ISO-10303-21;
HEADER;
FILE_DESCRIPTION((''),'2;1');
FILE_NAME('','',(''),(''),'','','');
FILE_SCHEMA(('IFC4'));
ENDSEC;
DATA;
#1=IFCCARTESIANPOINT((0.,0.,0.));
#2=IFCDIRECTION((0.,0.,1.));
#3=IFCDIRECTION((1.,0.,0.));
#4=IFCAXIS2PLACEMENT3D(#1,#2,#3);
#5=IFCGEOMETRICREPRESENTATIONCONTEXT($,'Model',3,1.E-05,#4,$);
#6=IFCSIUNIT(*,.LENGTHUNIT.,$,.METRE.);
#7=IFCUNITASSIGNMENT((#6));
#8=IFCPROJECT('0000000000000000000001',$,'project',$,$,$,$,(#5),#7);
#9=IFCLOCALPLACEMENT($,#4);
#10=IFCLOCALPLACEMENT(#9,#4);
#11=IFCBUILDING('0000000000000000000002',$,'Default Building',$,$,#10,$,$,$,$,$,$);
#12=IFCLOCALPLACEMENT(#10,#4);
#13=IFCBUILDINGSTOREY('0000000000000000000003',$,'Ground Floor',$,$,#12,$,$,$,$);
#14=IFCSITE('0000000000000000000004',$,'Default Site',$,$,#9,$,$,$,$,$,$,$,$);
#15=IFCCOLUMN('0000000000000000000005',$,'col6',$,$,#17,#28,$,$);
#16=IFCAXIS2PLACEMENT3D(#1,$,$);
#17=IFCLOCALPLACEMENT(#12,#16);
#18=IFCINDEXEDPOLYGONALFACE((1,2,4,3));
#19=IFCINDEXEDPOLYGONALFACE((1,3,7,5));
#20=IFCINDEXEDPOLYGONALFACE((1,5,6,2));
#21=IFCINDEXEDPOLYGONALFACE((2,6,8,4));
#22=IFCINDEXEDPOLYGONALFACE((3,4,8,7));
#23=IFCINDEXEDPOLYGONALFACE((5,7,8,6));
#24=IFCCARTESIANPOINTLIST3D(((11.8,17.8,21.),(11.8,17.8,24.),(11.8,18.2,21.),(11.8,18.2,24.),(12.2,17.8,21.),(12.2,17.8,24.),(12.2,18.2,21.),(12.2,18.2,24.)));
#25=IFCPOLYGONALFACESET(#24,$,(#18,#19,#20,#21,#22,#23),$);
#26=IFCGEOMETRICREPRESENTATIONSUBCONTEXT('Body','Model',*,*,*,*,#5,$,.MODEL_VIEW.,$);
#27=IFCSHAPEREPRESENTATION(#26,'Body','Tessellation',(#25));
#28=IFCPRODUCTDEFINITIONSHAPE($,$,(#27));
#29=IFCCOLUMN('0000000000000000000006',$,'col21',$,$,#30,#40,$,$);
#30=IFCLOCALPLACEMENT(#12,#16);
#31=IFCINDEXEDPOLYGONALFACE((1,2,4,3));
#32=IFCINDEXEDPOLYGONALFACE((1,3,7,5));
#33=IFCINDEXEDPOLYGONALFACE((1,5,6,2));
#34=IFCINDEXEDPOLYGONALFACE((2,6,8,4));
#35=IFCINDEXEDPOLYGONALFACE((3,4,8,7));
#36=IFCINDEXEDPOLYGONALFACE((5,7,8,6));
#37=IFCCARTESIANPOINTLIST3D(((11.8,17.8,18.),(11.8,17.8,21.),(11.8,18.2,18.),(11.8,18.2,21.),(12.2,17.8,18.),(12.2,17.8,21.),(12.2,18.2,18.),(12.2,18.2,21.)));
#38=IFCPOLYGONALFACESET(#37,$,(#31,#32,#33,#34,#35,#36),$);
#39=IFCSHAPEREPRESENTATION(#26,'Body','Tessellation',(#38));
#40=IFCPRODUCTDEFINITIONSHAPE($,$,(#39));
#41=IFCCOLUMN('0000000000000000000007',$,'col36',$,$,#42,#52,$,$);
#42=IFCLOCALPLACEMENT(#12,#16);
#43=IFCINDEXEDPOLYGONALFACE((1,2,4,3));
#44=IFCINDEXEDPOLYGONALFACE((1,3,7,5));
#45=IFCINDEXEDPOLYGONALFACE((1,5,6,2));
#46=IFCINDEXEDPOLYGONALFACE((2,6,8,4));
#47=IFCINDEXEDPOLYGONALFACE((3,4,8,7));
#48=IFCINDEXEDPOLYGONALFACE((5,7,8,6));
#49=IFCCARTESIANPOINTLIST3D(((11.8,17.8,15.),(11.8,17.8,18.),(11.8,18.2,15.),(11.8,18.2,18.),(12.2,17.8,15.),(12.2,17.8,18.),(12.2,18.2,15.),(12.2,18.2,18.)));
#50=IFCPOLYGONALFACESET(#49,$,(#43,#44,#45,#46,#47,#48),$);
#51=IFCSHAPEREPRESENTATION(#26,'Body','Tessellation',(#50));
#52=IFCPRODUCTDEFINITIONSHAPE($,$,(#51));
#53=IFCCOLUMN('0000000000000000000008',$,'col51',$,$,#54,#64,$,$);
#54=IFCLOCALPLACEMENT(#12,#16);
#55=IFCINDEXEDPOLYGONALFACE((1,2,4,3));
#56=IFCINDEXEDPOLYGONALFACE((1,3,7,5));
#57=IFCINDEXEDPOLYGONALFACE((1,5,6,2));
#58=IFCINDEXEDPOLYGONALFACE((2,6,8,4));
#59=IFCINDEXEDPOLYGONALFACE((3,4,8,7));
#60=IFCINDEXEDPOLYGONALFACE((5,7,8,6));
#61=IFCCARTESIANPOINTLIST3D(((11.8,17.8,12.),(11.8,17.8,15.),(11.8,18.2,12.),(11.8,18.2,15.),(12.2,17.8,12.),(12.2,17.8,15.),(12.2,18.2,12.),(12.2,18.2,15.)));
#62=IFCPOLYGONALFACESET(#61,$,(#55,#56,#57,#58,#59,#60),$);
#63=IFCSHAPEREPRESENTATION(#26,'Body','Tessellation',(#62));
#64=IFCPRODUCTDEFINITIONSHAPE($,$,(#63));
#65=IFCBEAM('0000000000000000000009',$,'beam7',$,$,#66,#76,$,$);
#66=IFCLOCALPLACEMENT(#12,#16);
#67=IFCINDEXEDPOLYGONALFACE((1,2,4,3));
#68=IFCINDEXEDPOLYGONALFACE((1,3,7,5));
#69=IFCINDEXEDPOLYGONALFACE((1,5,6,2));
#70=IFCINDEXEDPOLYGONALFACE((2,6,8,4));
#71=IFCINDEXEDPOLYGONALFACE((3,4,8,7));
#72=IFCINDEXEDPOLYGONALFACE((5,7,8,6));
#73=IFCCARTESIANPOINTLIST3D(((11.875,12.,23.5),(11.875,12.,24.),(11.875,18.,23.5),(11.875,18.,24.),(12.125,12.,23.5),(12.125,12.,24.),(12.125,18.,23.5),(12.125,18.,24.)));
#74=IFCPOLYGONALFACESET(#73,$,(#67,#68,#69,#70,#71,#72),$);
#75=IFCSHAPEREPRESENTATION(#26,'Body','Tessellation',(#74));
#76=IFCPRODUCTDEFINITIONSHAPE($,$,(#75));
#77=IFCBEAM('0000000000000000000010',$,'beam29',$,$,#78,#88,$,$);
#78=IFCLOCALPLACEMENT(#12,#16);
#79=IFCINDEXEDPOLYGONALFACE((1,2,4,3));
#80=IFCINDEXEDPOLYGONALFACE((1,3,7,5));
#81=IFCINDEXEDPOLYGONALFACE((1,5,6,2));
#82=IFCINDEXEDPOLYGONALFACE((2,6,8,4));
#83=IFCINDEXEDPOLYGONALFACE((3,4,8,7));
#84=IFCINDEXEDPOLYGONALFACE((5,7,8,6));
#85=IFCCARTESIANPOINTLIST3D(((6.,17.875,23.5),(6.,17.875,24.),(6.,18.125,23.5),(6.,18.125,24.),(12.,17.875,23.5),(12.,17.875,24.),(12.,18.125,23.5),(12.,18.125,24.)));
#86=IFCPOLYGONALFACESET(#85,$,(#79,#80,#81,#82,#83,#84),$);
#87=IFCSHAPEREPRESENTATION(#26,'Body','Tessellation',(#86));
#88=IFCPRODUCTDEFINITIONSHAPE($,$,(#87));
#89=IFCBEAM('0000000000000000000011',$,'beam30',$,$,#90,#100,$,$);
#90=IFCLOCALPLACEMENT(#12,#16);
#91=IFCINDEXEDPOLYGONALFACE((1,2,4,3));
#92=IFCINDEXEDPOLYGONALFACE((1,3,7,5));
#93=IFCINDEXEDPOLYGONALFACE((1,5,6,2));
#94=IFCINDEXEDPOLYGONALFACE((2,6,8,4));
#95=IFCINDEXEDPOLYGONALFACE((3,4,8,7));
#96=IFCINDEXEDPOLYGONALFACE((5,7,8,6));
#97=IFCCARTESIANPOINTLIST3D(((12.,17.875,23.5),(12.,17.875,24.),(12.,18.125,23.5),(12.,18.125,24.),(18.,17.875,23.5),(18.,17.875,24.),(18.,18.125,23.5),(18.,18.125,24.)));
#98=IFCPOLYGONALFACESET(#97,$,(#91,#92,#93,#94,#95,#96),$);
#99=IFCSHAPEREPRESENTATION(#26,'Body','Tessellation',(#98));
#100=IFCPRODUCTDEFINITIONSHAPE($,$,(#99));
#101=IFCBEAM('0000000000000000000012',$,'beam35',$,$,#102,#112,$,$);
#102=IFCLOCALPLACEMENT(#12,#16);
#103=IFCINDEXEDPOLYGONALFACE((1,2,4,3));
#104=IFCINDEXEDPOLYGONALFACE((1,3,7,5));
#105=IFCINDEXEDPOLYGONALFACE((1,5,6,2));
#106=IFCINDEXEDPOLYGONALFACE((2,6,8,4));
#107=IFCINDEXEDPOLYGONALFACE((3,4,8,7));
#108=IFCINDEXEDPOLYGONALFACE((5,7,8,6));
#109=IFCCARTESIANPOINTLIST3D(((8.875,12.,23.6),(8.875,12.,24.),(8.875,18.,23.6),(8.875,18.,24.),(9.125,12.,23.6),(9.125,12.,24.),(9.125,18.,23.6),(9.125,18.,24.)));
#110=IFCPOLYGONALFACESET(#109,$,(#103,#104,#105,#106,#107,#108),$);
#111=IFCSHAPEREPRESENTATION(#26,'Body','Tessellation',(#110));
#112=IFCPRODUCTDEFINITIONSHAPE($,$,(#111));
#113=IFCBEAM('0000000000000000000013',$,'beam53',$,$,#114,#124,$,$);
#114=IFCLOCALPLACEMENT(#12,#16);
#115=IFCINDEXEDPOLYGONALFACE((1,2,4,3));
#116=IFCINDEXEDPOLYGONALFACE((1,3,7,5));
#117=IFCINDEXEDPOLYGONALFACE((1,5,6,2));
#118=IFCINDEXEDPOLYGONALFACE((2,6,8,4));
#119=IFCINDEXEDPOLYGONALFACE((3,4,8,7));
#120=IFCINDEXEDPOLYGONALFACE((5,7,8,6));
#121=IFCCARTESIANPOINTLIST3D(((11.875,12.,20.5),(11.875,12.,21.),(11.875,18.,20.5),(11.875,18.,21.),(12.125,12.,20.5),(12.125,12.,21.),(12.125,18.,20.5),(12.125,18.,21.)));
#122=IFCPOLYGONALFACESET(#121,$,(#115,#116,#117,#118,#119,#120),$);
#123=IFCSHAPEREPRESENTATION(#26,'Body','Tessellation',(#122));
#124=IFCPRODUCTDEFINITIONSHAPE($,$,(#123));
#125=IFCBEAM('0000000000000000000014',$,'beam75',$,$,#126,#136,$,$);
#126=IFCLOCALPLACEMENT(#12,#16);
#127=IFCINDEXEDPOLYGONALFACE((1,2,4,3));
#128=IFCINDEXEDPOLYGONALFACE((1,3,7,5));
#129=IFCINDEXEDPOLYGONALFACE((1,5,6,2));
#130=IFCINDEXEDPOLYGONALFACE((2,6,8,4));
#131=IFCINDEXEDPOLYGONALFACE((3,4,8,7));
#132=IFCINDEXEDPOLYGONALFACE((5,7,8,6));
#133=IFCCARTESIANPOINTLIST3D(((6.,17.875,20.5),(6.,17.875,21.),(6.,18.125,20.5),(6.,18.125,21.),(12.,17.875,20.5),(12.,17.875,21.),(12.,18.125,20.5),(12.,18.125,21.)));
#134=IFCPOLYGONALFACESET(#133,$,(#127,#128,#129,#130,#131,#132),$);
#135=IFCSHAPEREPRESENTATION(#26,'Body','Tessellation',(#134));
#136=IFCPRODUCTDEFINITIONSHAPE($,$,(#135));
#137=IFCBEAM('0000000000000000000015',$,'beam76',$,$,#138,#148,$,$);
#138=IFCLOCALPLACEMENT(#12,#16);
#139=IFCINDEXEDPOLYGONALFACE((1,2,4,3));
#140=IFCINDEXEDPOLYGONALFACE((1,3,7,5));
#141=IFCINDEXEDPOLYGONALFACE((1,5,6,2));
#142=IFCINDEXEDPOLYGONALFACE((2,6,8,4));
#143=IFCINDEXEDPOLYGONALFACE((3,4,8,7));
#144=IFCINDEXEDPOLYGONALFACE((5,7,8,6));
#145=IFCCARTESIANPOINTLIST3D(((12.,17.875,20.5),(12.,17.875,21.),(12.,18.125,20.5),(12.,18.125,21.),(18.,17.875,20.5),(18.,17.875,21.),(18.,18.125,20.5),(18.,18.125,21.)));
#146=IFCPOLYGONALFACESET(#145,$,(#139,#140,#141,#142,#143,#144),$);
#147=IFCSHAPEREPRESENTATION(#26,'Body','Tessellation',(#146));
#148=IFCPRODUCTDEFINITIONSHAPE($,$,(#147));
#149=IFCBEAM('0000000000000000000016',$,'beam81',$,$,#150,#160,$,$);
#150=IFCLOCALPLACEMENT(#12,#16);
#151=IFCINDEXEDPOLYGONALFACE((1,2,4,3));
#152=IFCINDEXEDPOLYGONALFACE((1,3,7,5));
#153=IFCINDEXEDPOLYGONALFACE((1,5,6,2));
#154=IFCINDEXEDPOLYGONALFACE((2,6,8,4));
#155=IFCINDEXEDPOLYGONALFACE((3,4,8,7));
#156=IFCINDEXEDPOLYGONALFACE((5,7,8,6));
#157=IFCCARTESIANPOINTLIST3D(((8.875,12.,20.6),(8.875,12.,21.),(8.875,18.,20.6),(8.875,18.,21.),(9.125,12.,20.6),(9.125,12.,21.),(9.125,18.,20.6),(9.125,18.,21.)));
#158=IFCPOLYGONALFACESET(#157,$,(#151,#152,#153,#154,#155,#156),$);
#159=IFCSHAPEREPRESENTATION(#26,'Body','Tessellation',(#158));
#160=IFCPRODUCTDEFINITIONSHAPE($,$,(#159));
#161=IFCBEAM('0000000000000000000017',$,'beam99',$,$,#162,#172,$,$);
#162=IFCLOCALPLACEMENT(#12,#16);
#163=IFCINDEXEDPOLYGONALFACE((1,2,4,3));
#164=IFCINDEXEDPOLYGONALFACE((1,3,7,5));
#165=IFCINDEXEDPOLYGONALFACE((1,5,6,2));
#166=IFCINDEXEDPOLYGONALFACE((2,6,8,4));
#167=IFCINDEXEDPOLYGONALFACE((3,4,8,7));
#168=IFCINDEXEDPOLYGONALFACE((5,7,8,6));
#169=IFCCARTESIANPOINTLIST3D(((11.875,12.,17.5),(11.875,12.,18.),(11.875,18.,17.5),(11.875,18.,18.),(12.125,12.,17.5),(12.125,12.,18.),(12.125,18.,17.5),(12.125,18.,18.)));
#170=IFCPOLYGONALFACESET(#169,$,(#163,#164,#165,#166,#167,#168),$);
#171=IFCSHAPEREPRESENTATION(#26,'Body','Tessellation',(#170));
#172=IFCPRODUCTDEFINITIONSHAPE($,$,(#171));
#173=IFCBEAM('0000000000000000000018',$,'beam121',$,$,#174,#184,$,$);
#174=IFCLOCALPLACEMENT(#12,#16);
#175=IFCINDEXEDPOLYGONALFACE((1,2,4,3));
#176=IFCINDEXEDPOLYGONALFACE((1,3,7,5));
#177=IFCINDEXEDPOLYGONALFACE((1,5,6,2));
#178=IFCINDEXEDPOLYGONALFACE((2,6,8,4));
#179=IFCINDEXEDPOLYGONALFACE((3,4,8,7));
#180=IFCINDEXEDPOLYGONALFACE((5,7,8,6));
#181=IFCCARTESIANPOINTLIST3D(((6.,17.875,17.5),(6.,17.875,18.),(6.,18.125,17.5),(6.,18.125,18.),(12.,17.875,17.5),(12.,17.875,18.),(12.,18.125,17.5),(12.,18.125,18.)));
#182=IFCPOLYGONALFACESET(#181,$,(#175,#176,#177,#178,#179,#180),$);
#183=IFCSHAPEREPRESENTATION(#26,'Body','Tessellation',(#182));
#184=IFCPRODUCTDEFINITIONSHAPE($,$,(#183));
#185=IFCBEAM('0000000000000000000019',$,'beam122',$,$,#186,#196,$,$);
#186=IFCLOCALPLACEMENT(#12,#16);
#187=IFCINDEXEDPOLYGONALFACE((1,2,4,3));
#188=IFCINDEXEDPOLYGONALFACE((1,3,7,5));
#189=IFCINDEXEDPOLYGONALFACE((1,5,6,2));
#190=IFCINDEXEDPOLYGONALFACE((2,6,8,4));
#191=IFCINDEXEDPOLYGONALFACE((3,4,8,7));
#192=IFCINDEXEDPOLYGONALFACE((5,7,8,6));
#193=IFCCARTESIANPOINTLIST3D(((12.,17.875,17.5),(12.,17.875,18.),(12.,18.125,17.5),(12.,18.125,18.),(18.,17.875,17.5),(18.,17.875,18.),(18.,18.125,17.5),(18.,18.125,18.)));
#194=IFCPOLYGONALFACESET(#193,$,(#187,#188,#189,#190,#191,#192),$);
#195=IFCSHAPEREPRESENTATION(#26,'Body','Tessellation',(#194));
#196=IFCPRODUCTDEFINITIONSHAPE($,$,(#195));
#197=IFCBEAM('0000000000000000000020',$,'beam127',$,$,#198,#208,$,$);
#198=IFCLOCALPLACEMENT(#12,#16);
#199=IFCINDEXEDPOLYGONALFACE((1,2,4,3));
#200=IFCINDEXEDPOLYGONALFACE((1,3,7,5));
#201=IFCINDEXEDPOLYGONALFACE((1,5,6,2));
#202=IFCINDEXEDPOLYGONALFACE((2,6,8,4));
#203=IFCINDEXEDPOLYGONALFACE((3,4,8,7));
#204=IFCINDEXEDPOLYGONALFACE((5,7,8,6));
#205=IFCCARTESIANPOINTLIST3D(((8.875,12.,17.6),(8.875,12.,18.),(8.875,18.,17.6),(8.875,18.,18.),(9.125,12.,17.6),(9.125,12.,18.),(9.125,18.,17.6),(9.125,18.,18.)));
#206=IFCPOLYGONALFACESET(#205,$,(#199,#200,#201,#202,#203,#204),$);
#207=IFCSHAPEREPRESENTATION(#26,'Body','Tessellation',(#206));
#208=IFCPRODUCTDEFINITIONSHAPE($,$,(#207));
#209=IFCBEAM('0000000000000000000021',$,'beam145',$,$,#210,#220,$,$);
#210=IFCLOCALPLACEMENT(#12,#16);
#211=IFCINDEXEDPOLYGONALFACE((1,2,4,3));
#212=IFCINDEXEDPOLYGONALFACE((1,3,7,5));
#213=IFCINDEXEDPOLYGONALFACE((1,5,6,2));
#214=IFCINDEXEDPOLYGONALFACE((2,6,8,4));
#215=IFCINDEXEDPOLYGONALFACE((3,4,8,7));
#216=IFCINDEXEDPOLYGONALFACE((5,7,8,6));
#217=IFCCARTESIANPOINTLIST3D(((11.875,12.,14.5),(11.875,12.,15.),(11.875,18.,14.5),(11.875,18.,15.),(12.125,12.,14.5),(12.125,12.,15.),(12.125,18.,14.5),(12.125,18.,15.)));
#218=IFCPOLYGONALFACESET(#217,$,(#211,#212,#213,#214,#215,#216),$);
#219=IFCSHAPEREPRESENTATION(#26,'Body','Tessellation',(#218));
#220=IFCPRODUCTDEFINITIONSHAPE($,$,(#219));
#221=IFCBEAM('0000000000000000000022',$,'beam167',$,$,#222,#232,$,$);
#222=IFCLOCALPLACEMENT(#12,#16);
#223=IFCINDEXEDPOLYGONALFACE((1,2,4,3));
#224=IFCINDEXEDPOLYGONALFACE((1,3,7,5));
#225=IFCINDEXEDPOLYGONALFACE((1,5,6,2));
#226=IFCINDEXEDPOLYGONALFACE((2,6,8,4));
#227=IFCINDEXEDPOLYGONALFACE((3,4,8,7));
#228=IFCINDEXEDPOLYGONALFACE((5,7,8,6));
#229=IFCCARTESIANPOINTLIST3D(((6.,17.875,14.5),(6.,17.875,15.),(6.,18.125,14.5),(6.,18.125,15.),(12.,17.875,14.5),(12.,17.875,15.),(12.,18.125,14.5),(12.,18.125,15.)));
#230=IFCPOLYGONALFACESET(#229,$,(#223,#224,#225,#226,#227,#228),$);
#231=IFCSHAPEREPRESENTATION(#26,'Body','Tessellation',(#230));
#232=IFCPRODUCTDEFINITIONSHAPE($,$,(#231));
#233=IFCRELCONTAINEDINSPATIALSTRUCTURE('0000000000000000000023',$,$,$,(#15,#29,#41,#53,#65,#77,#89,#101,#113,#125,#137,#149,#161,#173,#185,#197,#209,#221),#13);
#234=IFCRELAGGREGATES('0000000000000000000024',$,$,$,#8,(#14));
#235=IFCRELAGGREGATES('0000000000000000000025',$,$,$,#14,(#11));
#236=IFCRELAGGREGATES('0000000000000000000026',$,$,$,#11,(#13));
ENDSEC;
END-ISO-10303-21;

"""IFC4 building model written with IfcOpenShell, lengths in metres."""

from ifc_helpers import new_model, si_unit, frame, origin_with_axes, place, context, subcontext, project, spatial, indexed_curve, outline, extrude, element, save


model = new_model("IFC4")

# Units and contexts
model_context = context("Model", 3, precision=1e-05, world=origin_with_axes())
body_context = subcontext(model_context, "Body", "Model", "MODEL_VIEW")
ifc_project = project(units=[si_unit("LENGTHUNIT", "METRE")], contexts=[model_context])

# Site, building, storey
site_placement = place(None, origin_with_axes())
site = spatial("IfcSite", under=ifc_project, at=site_placement, Name="Default Site")
building_placement = place(site_placement, origin_with_axes())
building = spatial("IfcBuilding", under=site, at=building_placement, Name="Default Building")
storey_placement = place(building_placement, origin_with_axes())
storey = spatial("IfcBuildingStorey", under=building, at=storey_placement, Name="Ground Floor")

# Columns
for number, where, z_axis, x_axis, name in (
    (1, (11.8, 17.8, 21.0), (0.0, 0.0, 1.0), (1.0, 0.0, 0.0), "col6"),
    (2, (11.8, 17.8, 18.0), (0.0, 0.0, 1.0), (1.0, 0.0, 0.0), "col21"),
    (3, (11.8, 17.8, 15.0), (0.0, 0.0, 1.0), (1.0, 0.0, 0.0), "col36"),
    (4, (11.8, 17.8, 12.0), (0.0, 0.0, 1.0), (1.0, 0.0, 0.0), "col51"),
):
    element("IfcColumn", number, at=place(storey_placement, frame(where, z_axis=z_axis, x_axis=x_axis)), inside=storey, Name=name, context=body_context, shape_type="SweptSolid", body=[
        extrude(outline(indexed_curve([(0.0, 0.0), (0.0, 0.4), (0.4, 0.4), (0.4, 0.0), (0.0, 0.0)], self_intersect=False)), origin_with_axes(), (0.0, 0.0, 1.0), 3.0),
    ])

# Beams
for number, where, z_axis, x_axis, name in (
    (5, (12.125, 12.0, 23.5), (0.0, 0.0, 1.0), (0.0, 1.0, 0.0), "beam7"),
    (6, (6.0, 17.875, 23.5), (0.0, 0.0, 1.0), (1.0, 0.0, 0.0), "beam29"),
    (7, (12.0, 17.875, 23.5), (0.0, 0.0, 1.0), (1.0, 0.0, 0.0), "beam30"),
):
    element("IfcBeam", number, at=place(storey_placement, frame(where, z_axis=z_axis, x_axis=x_axis)), inside=storey, Name=name, context=body_context, shape_type="SweptSolid", body=[
        extrude(outline(indexed_curve([(0.0, 0.0), (0.0, 0.25), (6.0, 0.25), (6.0, 0.0), (0.0, 0.0)], self_intersect=False)), origin_with_axes(), (0.0, 0.0, 1.0), 0.5),
    ])
beam_1_placement = place(storey_placement, frame((8.875, 18.0, 23.6), z_axis=(0.0, 0.0, 1.0), x_axis=(0.0, -1.0, 0.0)))
element("IfcBeam", 8, at=beam_1_placement, inside=storey, Name="beam35", context=body_context, shape_type="SweptSolid", body=[
    extrude(outline(indexed_curve([(0.0, 0.0), (0.0, 0.25), (6.0, 0.25), (6.0, 0.0), (0.0, 0.0)], self_intersect=False)), origin_with_axes(), (0.0, 0.0, 1.0), 0.4),
])
for number, where, z_axis, x_axis, name in (
    (9, (12.125, 12.0, 20.5), (0.0, 0.0, 1.0), (0.0, 1.0, 0.0), "beam53"),
    (10, (6.0, 17.875, 20.5), (0.0, 0.0, 1.0), (1.0, 0.0, 0.0), "beam75"),
    (11, (12.0, 17.875, 20.5), (0.0, 0.0, 1.0), (1.0, 0.0, 0.0), "beam76"),
):
    element("IfcBeam", number, at=place(storey_placement, frame(where, z_axis=z_axis, x_axis=x_axis)), inside=storey, Name=name, context=body_context, shape_type="SweptSolid", body=[
        extrude(outline(indexed_curve([(0.0, 0.0), (0.0, 0.25), (6.0, 0.25), (6.0, 0.0), (0.0, 0.0)], self_intersect=False)), origin_with_axes(), (0.0, 0.0, 1.0), 0.5),
    ])
beam_2_placement = place(storey_placement, frame((8.875, 18.0, 20.6), z_axis=(0.0, 0.0, 1.0), x_axis=(0.0, -1.0, 0.0)))
element("IfcBeam", 12, at=beam_2_placement, inside=storey, Name="beam81", context=body_context, shape_type="SweptSolid", body=[
    extrude(outline(indexed_curve([(0.0, 0.0), (0.0, 0.25), (6.0, 0.25), (6.0, 0.0), (0.0, 0.0)], self_intersect=False)), origin_with_axes(), (0.0, 0.0, 1.0), 0.4),
])
for number, where, z_axis, x_axis, name in (
    (13, (12.125, 12.0, 17.5), (0.0, 0.0, 1.0), (0.0, 1.0, 0.0), "beam99"),
    (14, (6.0, 17.875, 17.5), (0.0, 0.0, 1.0), (1.0, 0.0, 0.0), "beam121"),
    (15, (12.0, 17.875, 17.5), (0.0, 0.0, 1.0), (1.0, 0.0, 0.0), "beam122"),
):
    element("IfcBeam", number, at=place(storey_placement, frame(where, z_axis=z_axis, x_axis=x_axis)), inside=storey, Name=name, context=body_context, shape_type="SweptSolid", body=[
        extrude(outline(indexed_curve([(0.0, 0.0), (0.0, 0.25), (6.0, 0.25), (6.0, 0.0), (0.0, 0.0)], self_intersect=False)), origin_with_axes(), (0.0, 0.0, 1.0), 0.5),
    ])
beam_3_placement = place(storey_placement, frame((8.875, 18.0, 17.6), z_axis=(0.0, 0.0, 1.0), x_axis=(0.0, -1.0, 0.0)))
element("IfcBeam", 16, at=beam_3_placement, inside=storey, Name="beam127", context=body_context, shape_type="SweptSolid", body=[
    extrude(outline(indexed_curve([(0.0, 0.0), (0.0, 0.25), (6.0, 0.25), (6.0, 0.0), (0.0, 0.0)], self_intersect=False)), origin_with_axes(), (0.0, 0.0, 1.0), 0.4),
])
for number, where, z_axis, x_axis, name in (
    (17, (12.125, 12.0, 14.5), (0.0, 0.0, 1.0), (0.0, 1.0, 0.0), "beam145"),
    (18, (6.0, 17.875, 14.5), (0.0, 0.0, 1.0), (1.0, 0.0, 0.0), "beam167"),
):
    element("IfcBeam", number, at=place(storey_placement, frame(where, z_axis=z_axis, x_axis=x_axis)), inside=storey, Name=name, context=body_context, shape_type="SweptSolid", body=[
        extrude(outline(indexed_curve([(0.0, 0.0), (0.0, 0.25), (6.0, 0.25), (6.0, 0.0), (0.0, 0.0)], self_intersect=False)), origin_with_axes(), (0.0, 0.0, 1.0), 0.5),
    ])

save(model, "model.ifc")
